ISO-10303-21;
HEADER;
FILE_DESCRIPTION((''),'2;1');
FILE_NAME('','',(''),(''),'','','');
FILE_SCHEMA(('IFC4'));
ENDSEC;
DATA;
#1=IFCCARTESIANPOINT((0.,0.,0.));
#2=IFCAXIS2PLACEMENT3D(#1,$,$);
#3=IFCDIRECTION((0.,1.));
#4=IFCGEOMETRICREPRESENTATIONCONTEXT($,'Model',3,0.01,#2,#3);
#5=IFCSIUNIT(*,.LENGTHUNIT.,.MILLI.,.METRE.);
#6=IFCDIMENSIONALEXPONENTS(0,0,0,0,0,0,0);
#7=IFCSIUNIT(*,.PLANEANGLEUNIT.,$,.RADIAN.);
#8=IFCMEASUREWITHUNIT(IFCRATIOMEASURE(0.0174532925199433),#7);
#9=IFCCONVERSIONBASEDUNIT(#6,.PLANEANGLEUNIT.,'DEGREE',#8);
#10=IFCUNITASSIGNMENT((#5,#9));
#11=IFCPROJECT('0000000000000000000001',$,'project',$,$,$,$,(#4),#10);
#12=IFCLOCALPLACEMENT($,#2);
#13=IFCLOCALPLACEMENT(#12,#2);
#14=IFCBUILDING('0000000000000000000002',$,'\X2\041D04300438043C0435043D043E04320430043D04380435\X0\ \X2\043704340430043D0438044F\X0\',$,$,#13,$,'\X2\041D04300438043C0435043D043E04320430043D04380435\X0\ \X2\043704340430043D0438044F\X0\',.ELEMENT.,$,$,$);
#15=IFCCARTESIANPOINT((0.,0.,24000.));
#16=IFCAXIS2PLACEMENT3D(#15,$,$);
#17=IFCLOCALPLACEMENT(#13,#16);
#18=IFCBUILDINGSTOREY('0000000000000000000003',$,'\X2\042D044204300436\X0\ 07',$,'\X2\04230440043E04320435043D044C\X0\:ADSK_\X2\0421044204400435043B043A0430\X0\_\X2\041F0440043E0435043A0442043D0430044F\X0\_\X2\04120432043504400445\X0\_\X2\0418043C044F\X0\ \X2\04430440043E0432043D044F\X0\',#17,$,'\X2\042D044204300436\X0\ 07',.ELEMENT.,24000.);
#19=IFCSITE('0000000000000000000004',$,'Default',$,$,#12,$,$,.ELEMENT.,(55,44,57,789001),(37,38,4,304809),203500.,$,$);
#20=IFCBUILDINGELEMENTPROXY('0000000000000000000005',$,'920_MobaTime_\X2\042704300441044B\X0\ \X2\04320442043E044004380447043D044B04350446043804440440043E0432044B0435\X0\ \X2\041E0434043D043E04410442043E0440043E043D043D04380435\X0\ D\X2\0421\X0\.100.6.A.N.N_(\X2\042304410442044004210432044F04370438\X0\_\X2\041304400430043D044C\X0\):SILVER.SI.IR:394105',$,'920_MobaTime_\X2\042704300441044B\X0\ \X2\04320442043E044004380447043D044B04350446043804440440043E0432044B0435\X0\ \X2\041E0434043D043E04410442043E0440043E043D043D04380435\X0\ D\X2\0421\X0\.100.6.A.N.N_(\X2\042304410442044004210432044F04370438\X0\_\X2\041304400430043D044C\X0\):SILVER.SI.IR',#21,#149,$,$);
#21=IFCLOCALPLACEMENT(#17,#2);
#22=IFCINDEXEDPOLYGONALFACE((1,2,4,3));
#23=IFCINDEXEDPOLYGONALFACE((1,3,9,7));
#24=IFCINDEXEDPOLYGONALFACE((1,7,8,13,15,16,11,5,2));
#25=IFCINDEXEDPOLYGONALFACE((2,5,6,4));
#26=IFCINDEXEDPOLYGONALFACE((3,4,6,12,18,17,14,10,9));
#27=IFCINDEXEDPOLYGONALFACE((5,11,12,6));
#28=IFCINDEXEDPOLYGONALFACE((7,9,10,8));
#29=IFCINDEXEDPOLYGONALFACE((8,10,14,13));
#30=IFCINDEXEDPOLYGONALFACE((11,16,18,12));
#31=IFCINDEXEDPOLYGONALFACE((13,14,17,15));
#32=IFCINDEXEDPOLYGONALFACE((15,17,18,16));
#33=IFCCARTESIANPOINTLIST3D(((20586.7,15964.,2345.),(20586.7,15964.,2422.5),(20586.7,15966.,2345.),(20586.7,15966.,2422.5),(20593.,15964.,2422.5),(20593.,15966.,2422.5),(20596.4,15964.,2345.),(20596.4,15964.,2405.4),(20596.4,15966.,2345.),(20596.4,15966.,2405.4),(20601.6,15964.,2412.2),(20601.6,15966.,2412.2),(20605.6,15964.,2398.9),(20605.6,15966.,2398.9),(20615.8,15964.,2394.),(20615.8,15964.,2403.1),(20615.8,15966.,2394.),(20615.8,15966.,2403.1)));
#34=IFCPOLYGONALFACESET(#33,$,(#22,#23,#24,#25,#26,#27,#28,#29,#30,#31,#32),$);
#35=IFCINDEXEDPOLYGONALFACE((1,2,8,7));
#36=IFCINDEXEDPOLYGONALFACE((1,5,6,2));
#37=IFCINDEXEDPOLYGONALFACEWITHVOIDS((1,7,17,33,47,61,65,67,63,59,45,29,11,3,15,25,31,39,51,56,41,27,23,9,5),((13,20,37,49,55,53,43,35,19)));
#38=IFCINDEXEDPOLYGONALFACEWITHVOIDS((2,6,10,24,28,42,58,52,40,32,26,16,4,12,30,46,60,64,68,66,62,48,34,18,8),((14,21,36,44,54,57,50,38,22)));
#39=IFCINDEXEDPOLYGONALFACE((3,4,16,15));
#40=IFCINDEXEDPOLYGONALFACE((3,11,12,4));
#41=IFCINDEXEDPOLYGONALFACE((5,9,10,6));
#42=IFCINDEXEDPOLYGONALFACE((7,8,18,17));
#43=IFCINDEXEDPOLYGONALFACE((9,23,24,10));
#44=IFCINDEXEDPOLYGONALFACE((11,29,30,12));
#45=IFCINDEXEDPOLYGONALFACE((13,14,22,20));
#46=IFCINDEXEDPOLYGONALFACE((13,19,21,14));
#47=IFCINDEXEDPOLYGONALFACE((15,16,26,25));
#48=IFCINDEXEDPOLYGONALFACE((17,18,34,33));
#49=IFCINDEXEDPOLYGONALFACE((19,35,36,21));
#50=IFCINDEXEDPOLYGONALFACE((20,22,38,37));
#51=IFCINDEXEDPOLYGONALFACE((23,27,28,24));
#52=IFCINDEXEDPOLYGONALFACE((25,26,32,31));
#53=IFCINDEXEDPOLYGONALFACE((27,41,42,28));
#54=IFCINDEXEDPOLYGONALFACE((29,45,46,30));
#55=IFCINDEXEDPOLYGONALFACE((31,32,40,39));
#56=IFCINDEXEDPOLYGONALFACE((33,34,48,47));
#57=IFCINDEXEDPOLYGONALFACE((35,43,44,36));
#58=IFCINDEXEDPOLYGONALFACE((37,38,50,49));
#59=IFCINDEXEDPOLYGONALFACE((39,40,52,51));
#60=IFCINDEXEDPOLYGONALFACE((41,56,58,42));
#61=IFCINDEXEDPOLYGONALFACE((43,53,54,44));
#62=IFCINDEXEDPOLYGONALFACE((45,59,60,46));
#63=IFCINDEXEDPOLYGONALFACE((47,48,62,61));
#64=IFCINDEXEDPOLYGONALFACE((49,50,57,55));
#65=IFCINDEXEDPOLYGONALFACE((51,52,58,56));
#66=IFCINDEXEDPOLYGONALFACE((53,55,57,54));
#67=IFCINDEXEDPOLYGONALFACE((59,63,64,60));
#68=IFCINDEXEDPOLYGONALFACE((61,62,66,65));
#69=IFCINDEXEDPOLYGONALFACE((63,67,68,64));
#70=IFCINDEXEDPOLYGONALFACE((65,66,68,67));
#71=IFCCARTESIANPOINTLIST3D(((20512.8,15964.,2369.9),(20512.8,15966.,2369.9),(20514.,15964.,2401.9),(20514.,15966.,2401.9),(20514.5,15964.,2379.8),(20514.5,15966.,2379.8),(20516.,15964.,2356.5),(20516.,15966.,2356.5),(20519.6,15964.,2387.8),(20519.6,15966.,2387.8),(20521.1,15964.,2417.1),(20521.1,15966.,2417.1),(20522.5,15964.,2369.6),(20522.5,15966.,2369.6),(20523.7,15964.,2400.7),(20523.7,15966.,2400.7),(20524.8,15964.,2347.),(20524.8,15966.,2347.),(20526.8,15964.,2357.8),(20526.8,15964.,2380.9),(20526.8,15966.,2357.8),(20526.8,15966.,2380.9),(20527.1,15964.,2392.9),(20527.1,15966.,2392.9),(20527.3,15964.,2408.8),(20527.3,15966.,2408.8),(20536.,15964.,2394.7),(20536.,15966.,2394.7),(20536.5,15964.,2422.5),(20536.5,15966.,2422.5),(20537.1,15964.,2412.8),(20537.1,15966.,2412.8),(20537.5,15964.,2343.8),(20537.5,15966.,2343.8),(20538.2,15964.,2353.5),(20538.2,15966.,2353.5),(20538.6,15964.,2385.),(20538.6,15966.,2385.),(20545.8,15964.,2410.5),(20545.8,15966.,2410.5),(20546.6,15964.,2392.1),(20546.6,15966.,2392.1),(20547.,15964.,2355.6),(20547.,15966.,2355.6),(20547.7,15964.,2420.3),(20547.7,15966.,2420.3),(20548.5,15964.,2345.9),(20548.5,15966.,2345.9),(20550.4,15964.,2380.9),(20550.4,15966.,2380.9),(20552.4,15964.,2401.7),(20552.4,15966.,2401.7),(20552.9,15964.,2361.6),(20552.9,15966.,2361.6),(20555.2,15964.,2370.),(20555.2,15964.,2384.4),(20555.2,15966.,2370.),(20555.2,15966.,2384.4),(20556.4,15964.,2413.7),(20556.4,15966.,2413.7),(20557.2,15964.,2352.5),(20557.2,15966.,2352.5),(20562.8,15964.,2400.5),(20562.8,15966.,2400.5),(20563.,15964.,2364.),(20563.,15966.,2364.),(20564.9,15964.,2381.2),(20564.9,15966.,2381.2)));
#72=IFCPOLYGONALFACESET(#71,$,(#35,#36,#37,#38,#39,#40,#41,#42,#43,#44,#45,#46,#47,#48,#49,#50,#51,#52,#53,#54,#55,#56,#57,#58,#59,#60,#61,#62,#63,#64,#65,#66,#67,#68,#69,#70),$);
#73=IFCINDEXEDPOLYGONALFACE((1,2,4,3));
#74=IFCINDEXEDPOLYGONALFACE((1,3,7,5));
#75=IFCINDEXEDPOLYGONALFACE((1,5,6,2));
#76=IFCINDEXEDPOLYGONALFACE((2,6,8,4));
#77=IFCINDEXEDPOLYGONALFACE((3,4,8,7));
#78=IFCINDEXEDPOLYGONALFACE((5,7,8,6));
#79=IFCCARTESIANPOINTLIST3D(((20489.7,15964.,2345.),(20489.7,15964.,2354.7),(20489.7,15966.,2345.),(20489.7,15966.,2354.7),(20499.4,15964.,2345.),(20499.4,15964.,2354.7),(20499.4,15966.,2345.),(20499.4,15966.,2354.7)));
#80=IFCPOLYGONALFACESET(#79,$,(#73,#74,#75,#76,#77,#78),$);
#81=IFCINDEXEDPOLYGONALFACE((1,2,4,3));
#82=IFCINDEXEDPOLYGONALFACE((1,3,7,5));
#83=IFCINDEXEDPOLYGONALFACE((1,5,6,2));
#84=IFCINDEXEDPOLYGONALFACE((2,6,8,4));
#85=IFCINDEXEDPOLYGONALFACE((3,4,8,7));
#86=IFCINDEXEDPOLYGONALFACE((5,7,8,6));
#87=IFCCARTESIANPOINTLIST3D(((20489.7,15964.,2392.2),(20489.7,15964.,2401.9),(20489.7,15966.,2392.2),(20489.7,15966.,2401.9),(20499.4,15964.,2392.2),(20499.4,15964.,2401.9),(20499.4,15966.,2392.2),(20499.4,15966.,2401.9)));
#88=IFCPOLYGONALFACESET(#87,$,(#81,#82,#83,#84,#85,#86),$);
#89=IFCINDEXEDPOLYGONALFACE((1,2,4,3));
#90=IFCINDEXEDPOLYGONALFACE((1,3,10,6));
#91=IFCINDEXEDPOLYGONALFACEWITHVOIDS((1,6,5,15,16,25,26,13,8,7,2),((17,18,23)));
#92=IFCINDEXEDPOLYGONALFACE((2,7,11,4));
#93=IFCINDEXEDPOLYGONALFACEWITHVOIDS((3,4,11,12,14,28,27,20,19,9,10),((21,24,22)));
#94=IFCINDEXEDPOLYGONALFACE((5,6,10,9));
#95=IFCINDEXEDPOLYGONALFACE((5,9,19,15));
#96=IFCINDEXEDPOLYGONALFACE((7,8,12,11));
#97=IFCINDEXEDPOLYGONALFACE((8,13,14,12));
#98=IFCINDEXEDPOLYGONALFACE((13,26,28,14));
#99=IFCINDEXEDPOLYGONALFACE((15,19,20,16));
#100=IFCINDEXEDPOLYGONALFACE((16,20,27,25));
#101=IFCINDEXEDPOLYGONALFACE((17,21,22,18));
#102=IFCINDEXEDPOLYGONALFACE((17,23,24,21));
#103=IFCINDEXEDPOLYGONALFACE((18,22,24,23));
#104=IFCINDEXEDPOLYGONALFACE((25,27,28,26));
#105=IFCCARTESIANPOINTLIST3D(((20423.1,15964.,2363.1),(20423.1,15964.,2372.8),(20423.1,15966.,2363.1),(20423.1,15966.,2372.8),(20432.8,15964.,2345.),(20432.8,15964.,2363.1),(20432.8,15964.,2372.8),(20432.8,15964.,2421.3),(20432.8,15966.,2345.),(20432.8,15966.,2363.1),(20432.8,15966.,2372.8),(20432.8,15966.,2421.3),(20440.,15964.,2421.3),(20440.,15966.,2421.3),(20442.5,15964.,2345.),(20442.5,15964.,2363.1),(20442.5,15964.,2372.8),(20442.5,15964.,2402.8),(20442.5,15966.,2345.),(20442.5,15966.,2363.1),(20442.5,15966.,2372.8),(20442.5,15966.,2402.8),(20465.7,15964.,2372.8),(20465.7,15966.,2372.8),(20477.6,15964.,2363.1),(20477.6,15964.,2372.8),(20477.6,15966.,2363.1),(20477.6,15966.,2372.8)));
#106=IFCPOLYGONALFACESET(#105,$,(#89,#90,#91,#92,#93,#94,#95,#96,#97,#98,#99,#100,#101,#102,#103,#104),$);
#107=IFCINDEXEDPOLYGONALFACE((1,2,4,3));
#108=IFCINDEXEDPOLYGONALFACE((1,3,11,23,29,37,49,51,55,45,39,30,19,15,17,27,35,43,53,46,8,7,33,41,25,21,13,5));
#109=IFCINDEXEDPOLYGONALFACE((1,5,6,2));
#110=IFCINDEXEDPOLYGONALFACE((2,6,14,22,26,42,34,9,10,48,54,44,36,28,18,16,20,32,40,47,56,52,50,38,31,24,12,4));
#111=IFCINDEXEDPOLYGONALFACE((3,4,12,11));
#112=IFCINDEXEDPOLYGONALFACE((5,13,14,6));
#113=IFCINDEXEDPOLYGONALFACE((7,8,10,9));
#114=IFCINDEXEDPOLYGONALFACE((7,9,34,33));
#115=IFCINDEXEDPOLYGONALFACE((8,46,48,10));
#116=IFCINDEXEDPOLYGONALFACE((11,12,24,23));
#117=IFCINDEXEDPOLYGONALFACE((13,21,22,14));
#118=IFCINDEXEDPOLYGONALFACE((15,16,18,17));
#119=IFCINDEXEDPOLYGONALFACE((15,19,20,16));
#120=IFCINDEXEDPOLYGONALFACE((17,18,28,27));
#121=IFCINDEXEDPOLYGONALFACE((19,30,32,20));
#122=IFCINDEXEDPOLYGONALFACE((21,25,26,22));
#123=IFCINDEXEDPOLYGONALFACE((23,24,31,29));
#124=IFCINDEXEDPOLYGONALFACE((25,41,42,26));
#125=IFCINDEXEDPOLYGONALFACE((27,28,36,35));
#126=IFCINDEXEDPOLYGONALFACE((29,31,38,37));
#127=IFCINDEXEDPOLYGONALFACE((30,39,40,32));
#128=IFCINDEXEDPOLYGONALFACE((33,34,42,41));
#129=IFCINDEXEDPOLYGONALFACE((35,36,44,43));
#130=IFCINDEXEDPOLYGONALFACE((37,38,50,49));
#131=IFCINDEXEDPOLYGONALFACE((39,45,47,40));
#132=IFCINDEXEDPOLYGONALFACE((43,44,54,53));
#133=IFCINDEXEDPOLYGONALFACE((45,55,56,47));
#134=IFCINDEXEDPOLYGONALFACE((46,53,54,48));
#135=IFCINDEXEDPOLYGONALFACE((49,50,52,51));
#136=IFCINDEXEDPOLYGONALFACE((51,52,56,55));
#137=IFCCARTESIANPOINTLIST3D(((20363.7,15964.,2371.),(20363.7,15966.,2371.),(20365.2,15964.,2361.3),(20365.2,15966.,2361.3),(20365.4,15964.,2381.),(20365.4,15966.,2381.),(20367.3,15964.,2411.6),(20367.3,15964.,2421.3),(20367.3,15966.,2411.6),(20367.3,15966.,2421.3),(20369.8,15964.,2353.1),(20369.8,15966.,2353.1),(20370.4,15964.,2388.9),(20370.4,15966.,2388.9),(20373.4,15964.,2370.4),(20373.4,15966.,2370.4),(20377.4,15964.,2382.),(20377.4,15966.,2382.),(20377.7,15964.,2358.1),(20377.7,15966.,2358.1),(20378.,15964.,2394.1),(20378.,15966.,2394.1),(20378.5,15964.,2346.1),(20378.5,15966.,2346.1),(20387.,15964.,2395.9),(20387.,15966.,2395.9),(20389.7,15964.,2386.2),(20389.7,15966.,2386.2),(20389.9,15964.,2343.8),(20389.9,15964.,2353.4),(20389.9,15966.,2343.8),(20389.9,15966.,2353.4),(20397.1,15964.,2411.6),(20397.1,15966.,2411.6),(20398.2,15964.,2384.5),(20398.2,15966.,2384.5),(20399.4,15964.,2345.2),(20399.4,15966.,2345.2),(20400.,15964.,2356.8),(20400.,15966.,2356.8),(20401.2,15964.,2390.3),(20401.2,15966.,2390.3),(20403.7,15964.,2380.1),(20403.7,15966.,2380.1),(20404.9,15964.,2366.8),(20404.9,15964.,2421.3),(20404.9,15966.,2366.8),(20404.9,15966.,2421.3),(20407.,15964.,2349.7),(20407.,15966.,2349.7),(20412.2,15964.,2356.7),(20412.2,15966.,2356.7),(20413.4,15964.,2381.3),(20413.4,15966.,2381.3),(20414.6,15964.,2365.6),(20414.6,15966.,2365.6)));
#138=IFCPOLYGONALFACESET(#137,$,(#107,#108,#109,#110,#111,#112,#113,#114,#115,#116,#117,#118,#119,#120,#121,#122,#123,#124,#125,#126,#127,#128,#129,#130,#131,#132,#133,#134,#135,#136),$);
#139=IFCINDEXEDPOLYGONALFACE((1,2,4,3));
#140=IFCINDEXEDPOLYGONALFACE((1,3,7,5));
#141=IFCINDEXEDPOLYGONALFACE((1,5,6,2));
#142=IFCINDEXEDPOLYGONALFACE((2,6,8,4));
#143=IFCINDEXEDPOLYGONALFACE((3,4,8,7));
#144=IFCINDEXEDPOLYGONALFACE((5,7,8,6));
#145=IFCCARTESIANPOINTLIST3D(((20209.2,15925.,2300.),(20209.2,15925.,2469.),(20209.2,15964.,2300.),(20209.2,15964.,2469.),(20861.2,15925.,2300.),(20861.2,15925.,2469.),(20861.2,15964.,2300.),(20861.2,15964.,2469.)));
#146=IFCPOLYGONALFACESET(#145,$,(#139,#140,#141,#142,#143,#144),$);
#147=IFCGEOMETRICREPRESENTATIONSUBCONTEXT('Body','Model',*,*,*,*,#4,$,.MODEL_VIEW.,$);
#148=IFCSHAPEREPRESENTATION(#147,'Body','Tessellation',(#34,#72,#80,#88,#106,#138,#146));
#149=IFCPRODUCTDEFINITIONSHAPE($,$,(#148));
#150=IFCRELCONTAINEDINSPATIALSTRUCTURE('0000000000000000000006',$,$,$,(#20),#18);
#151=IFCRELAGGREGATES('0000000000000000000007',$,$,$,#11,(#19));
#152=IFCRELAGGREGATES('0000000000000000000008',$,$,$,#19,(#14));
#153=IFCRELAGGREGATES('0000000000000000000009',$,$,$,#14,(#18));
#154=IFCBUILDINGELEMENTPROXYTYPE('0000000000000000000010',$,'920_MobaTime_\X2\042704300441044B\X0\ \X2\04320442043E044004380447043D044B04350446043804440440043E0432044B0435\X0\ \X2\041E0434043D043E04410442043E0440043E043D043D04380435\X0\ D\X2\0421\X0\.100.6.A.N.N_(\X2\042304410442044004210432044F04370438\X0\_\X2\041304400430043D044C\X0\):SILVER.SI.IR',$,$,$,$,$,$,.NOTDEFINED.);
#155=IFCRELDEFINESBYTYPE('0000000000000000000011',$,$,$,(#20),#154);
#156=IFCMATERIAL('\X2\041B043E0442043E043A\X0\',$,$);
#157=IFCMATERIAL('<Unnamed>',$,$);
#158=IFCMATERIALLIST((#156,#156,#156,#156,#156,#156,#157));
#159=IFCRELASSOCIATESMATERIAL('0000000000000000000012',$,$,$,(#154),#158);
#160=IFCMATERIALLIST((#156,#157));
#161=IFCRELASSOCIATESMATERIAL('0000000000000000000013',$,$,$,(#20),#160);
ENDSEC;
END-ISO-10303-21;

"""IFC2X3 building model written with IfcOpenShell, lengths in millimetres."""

from ifc_helpers import new_model, entity, si_unit, converted_unit, direction, frame, origin, origin_2d_with_axis, place, context, subcontext, project, spatial, polyline, rectangle, outline, extrude, source, transform, mapped, material, material_list, type_object, type_shapes, element, save


model = new_model("IFC2X3")

# Units and contexts
model_context = context("Model", 3, precision=0.01, world=origin(), true_north=direction((0.0, 1.0)))
body_context = subcontext(model_context, "Body", "Model", "MODEL_VIEW")
ifc_project = project(units=[si_unit("LENGTHUNIT", "METRE", prefix="MILLI"), converted_unit("PLANEANGLEUNIT", "DEGREE", entity("IfcRatioMeasure", 0.0174532925199433), si_unit("PLANEANGLEUNIT", "RADIAN"), dimensions=[0, 0, 0, 0, 0, 0, 0])], contexts=[model_context])

# Site, building, storey
site_placement = place(None, origin())
site = spatial("IfcSite", under=ifc_project, at=site_placement, Name="Default", CompositionType="ELEMENT", RefLatitude=(55, 44, 57, 789001), RefLongitude=(37, 38, 4, 304809), RefElevation=203500.0)
building_placement = place(site_placement, origin())
building = spatial("IfcBuilding", under=site, at=building_placement, Name="Наименование здания", LongName="Наименование здания", CompositionType="ELEMENT")
storey_placement = place(building_placement, frame((0.0, 0.0, 24000.0)))
storey = spatial("IfcBuildingStorey", under=building, at=storey_placement, Name="Этаж 07", ObjectType="Уровень:ADSK_Стрелка_Проектная_Вверх_Имя уровня", LongName="Этаж 07", CompositionType="ELEMENT", Elevation=24000.0)

# Building element proxy
ifc_material_1 = material(Name="Лоток")
ifc_material_2 = material(Name="<Unnamed>")
ifc_material_list_1 = material_list([ifc_material_1, ifc_material_2])
ifc_material_list_2 = material_list([ifc_material_1, ifc_material_1, ifc_material_1, ifc_material_1, ifc_material_1, ifc_material_1, ifc_material_2])
building_element_proxy_type = type_object("IfcBuildingElementProxyType", Name="920_MobaTime_Часы вторичныецифровые Односторонние DС.100.6.A.N.N_(УстрСвязи_Грань):SILVER.SI.IR", PredefinedType="NOTDEFINED", material=ifc_material_list_2)
shared_shape = source(origin(), body_context, "Body", "SweptSolid", [
    extrude(outline(polyline([(-49.3, -13.1), (28.2, -13.1), (28.2, -6.8), (17.9, 1.8), (8.8, 16.0), (-0.3, 16.0), (4.6, 5.8), (11.1, -3.4), (-49.3, -3.4), (-49.3, -13.1)])), frame((-64.6, 9.8, 39.0), z_axis=(0.0, 0.0, 1.0), x_axis=(0.0, 1.0, 0.0)), (0.0, 0.0, 1.0), 2.0),
    extrude(outline(polyline([(2.2, -27.6), (19.0, -27.6), (30.5, -16.1), (33.3, -4.9), (31.0, 5.8), (21.8, 17.2), (5.2, 27.3), (-11.1, 33.0), (-24.0, 32.7), (-33.6, 27.6), (-40.3, 18.6), (-42.8, 5.7), (-38.0, -6.3), (-27.2, -14.9), (-17.5, -17.7), (-8.2, -16.4), (-0.3, -11.9), (5.1, -4.5), (7.3, 6.2), (4.0, 17.2), (18.4, 7.3), (23.6, -2.4), (22.0, -11.4), (14.2, -18.4), (5.3, -18.3), (2.2, -27.6)]), holes=[polyline([(-9.0, 23.3), (-1.3, 14.3), (-2.5, 2.0), (-11.4, -7.0), (-23.4, -6.0), (-32.2, 2.9), (-31.2, 15.1), (-25.6, 22.1), (-17.5, 24.9), (-9.0, 23.3)])]), frame((-2.7, 3.6, 39.0), z_axis=(0.0, 0.0, 1.0), x_axis=(-0.427649, 0.903945, 0.0)), (0.0, 0.0, 1.0), 2.0),
    extrude(rectangle(XDim=9.7, YDim=9.7, at=origin_2d_with_axis()), frame((40.6, -34.7, 39.0)), (0.0, 0.0, 1.0), 2.0),
    extrude(rectangle(XDim=9.7, YDim=9.7, at=origin_2d_with_axis()), frame((40.6, 12.6, 39.0)), (0.0, 0.0, 1.0), 2.0),
    extrude(outline(polyline([(-0.9, -28.1), (8.8, -28.1), (8.8, -9.9), (18.5, -9.9), (18.5, -0.2), (8.8, -0.2), (8.8, 48.3), (1.5, 48.3), (-36.0, -0.2), (-36.0, -9.9), (-0.9, -9.9), (-0.9, -28.1)]), holes=[polyline([(-0.9, -0.2), (-24.1, -0.2), (-0.9, 29.7), (-0.9, -0.2)])]), frame((93.6, -11.4, 39.0)), (0.0, 0.0, 1.0), 2.0),
    extrude(outline(polyline([(3.3, -28.3), (12.5, -28.3), (20.5, -25.0), (26.8, -18.9), (30.7, -10.0), (31.4, 1.6), (26.9, 11.8), (20.1, 18.4), (11.1, 22.3), (1.0, 23.3), (-7.9, 20.4), (-14.9, 14.5), (-18.9, 6.2), (-17.1, -9.0), (-36.7, 0.5), (-29.1, 29.2), (-38.5, 31.7), (-48.1, -4.6), (-11.6, -23.1), (-8.0, -14.0), (-10.8, -7.6), (-10.2, 1.1), (-3.0, 11.8), (9.2, 12.8), (20.0, 5.5), (21.4, -7.5), (15.5, -16.4), (4.6, -18.6), (3.3, -28.3)])), frame((147.1, -8.5, 39.0), z_axis=(0.0, 0.0, 1.0), x_axis=(0.256974, -0.966418, 0.0)), (0.0, 0.0, 1.0), 2.0),
    extrude(rectangle(XDim=652.0, YDim=169.0, at=origin_2d_with_axis()), frame((0.0, 0.0, 0.0), z_axis=(0.0, 0.0, 1.0), x_axis=(-1.0, 0.0, 0.0)), (0.0, 0.0, 1.0), 39.0),
])
type_shapes(building_element_proxy_type, [shared_shape])
for number, where, z_axis, x_axis, name in (
    (1, (20535.2, 15925.0, 2384.5), (0.0, 1.0, 0.0), (-1.0, 0.0, 0.0), "920_MobaTime_Часы вторичныецифровые Односторонние DС.100.6.A.N.N_(УстрСвязи_Грань):SILVER.SI.IR:394105"),
):
    element("IfcBuildingElementProxy", number, at=place(storey_placement, frame(where, z_axis=z_axis, x_axis=x_axis)), inside=storey, type_object=building_element_proxy_type, material=ifc_material_list_1, Name=name, ObjectType="920_MobaTime_Часы вторичныецифровые Односторонние DС.100.6.A.N.N_(УстрСвязи_Грань):SILVER.SI.IR", context=body_context, shape_type="MappedRepresentation", body=[
        mapped(shared_shape, transform((0.0, 0.0, 0.0), scale=1.0)),
    ])

save(model, "model.ifc")
